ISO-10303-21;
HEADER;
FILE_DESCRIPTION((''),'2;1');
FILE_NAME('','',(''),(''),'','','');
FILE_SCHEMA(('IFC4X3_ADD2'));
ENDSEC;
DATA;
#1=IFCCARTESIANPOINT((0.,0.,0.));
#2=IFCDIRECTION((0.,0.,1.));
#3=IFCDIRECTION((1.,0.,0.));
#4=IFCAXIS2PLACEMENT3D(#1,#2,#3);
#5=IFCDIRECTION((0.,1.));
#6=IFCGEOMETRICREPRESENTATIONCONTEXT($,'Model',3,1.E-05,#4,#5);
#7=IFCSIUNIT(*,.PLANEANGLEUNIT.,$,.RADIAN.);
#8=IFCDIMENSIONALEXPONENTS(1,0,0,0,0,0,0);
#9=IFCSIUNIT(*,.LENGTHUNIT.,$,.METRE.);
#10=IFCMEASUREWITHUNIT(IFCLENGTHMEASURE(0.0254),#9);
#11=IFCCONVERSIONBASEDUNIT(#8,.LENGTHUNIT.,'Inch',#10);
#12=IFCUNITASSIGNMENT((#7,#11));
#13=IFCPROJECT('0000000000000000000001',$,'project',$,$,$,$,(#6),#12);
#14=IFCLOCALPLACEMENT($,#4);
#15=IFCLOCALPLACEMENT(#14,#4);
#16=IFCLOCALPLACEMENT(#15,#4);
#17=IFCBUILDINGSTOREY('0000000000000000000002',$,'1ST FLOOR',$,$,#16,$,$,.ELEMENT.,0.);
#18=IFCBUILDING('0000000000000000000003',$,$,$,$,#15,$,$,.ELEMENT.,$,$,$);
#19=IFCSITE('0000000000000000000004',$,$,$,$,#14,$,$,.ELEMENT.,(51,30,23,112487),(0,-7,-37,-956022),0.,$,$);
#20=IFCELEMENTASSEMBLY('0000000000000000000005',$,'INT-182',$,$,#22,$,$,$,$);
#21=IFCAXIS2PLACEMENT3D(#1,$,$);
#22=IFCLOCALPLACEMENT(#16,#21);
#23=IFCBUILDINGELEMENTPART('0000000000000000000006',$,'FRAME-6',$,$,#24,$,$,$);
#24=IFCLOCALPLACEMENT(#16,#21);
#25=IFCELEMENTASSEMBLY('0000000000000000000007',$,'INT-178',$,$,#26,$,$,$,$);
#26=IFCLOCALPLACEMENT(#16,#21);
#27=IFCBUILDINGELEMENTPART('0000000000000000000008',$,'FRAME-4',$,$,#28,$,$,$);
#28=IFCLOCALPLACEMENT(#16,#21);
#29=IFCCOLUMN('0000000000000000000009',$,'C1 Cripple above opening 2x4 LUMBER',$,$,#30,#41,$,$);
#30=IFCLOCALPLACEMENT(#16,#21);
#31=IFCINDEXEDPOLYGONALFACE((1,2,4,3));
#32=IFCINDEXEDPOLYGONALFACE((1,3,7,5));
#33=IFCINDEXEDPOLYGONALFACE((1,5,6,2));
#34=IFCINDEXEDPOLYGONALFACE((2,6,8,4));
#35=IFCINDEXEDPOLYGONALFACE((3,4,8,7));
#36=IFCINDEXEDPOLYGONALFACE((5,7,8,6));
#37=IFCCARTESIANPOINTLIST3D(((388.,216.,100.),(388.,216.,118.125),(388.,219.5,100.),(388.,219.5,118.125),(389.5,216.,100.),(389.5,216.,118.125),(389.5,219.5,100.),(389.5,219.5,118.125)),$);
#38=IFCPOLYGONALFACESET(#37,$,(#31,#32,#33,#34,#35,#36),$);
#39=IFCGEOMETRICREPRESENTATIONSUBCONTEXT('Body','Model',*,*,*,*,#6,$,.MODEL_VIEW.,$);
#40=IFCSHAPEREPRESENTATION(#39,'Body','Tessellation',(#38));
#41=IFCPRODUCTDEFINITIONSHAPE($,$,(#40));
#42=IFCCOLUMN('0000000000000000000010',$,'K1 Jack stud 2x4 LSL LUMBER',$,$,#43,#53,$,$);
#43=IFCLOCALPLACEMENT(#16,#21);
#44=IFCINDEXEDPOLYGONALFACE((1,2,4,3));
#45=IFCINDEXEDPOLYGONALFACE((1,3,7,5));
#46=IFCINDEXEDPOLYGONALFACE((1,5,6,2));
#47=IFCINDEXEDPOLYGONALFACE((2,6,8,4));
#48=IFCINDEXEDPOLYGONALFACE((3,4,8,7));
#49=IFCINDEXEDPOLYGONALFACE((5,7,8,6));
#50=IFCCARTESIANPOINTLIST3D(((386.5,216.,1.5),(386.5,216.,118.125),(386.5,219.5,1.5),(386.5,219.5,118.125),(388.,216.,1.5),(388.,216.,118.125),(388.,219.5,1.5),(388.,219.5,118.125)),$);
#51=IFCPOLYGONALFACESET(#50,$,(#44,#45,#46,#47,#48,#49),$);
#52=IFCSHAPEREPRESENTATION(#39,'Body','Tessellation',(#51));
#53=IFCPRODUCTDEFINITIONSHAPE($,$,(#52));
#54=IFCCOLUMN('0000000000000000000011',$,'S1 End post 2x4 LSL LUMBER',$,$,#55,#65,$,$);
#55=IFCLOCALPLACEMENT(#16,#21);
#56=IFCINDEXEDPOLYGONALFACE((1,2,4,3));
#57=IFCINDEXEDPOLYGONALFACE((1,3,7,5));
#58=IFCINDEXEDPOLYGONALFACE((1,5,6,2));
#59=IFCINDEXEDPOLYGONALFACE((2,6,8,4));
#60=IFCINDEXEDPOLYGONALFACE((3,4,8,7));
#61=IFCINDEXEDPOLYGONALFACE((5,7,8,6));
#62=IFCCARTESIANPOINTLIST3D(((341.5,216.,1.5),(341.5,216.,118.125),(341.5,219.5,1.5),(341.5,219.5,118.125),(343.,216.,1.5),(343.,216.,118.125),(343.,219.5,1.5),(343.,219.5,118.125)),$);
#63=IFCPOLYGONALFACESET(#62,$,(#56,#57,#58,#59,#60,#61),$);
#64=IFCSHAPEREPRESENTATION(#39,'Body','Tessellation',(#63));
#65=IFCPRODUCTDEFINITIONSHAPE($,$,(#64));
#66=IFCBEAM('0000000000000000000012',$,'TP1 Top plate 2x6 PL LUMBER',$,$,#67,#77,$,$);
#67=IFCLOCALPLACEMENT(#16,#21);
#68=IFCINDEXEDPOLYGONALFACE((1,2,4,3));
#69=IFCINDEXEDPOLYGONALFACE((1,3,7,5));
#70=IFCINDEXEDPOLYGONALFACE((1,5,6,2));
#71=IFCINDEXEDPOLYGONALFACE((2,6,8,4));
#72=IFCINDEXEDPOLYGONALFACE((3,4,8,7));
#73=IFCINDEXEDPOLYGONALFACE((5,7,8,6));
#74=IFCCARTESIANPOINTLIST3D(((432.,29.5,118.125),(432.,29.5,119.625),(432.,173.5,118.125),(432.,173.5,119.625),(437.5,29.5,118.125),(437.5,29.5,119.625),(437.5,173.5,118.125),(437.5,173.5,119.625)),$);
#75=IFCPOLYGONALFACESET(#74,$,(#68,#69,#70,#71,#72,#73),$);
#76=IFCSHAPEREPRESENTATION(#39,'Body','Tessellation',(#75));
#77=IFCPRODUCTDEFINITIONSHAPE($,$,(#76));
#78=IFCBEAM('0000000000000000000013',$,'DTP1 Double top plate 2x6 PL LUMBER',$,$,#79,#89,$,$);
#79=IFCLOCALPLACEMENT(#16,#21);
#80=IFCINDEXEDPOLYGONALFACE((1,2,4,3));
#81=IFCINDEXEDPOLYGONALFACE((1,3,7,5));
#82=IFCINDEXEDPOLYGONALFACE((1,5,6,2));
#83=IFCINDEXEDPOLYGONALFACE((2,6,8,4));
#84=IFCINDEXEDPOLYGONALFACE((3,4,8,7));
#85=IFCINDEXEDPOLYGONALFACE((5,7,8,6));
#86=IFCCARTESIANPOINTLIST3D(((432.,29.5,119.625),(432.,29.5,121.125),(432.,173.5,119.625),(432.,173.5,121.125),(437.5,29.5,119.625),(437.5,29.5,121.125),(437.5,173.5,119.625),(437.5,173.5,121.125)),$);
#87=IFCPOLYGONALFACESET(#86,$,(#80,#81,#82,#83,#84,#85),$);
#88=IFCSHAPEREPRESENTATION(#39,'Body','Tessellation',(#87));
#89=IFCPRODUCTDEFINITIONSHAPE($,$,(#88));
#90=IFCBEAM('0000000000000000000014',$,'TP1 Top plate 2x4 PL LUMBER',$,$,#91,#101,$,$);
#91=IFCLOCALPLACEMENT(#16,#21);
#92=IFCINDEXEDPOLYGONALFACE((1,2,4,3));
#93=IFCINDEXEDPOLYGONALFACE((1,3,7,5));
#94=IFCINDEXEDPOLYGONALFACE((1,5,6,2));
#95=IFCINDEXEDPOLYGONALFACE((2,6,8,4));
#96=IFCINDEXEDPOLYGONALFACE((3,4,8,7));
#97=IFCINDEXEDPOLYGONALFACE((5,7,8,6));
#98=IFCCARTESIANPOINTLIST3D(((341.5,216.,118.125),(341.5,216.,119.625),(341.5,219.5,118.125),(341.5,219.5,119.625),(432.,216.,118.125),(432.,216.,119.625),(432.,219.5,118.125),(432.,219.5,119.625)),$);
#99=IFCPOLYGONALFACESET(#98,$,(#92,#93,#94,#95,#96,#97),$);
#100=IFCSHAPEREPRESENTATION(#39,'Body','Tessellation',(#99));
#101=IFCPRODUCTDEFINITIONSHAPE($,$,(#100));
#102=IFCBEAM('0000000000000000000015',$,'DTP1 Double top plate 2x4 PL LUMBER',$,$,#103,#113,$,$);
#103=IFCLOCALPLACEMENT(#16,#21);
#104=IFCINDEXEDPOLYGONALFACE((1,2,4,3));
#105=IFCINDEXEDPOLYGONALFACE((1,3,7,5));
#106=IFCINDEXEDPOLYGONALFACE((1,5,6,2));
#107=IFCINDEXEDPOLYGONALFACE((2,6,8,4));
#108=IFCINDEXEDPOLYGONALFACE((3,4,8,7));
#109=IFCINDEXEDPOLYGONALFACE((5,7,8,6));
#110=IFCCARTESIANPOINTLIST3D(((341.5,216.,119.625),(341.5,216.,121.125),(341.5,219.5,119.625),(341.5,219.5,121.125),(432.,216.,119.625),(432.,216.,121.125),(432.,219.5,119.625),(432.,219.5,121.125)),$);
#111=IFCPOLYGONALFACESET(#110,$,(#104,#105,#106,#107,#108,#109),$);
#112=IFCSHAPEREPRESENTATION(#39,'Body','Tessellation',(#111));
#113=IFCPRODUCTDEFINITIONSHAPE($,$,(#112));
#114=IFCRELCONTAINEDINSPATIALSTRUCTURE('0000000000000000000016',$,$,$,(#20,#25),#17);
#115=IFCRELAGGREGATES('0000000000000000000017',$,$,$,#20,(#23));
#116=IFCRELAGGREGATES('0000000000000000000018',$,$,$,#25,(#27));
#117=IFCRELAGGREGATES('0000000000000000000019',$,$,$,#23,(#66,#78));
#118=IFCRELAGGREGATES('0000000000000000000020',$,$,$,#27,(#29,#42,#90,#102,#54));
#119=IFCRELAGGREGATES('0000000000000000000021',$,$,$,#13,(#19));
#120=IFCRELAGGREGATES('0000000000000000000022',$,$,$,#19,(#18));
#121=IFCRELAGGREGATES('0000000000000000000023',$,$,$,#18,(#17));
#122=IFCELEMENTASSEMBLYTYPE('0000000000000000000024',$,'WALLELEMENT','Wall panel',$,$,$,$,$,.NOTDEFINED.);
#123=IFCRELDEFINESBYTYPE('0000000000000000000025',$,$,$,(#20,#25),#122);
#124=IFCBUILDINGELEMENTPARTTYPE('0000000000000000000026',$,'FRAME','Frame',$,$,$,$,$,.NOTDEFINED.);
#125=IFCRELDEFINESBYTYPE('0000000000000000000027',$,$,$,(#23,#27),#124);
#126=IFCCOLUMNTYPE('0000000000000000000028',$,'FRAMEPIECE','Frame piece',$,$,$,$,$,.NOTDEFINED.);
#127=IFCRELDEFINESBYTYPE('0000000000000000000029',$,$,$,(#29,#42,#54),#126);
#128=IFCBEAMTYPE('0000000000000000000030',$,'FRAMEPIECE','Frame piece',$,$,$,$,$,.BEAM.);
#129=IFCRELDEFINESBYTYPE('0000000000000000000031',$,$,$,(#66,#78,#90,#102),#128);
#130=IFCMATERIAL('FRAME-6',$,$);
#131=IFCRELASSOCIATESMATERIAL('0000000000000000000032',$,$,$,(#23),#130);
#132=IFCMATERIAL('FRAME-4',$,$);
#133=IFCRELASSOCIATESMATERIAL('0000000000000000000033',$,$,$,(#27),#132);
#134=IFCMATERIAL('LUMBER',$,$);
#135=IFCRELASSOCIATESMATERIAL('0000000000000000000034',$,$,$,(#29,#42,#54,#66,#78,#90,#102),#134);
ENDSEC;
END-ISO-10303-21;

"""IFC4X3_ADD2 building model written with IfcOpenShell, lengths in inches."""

from ifc_helpers import new_model, entity, si_unit, converted_unit, direction, frame, origin_with_axes, origin_2d_with_axis, place, context, subcontext, project, spatial, rectangle, extrude, material, type_object, element, aggregate, save


model = new_model("IFC4X3_ADD2")

# Units and contexts
model_context = context("Model", 3, precision=1e-05, world=origin_with_axes(), true_north=direction((0.0, 1.0)))
body_context = subcontext(model_context, "Body", "Model", "MODEL_VIEW")
ifc_project = project(units=[si_unit("PLANEANGLEUNIT", "RADIAN"), converted_unit("LENGTHUNIT", "Inch", entity("IfcLengthMeasure", 0.0254), si_unit("LENGTHUNIT", "METRE"), dimensions=[1, 0, 0, 0, 0, 0, 0])], contexts=[model_context])

# Site, building, storey
site_placement = place(None, origin_with_axes())
site = spatial("IfcSite", under=ifc_project, at=site_placement, CompositionType="ELEMENT", RefLatitude=(51, 30, 23, 112487), RefLongitude=(0, -7, -37, -956022), RefElevation=0.0)
building_placement = place(site_placement, origin_with_axes())
building = spatial("IfcBuilding", under=site, at=building_placement, CompositionType="ELEMENT")
storey_placement = place(building_placement, origin_with_axes())
storey = spatial("IfcBuildingStorey", under=building, at=storey_placement, Name="1ST FLOOR", CompositionType="ELEMENT", Elevation=0.0)

# Element assemblies, building element parts, columns
element_assembly_type = type_object("IfcElementAssemblyType", Name="WALLELEMENT", Description="Wall panel", PredefinedType="NOTDEFINED")
ifc_material_1 = material(Name="FRAME-4")
building_element_part_type = type_object("IfcBuildingElementPartType", Name="FRAME", Description="Frame", PredefinedType="NOTDEFINED")
ifc_material_2 = material(Name="LUMBER")
column_type = type_object("IfcColumnType", Name="FRAMEPIECE", Description="Frame piece", PredefinedType="NOTDEFINED")
assembly_1_placement = place(storey_placement, origin_with_axes())
assembly_1 = element("IfcElementAssembly", 1, at=assembly_1_placement, inside=storey, type_object=element_assembly_type, Name="INT-182")
ifc_material_3 = material(Name="FRAME-6")
building_element_part_1_placement = place(storey_placement, origin_with_axes())
building_element_part_1 = element("IfcBuildingElementPart", 2, at=building_element_part_1_placement, type_object=building_element_part_type, material=ifc_material_3, Name="FRAME-6")
aggregate(assembly_1, [building_element_part_1])
assembly_2_placement = place(storey_placement, origin_with_axes())
assembly_2 = element("IfcElementAssembly", 3, at=assembly_2_placement, inside=storey, type_object=element_assembly_type, Name="INT-178")
building_element_part_2_placement = place(storey_placement, origin_with_axes())
building_element_part_2 = element("IfcBuildingElementPart", 4, at=building_element_part_2_placement, type_object=building_element_part_type, material=ifc_material_1, Name="FRAME-4")
aggregate(assembly_2, [building_element_part_2])
column_1_placement = place(storey_placement, frame((388.75, 217.75, 118.125), z_axis=(0.0, 0.0, -1.0), x_axis=(1.0, 0.0, 0.0)))
column_1 = element("IfcColumn", 5, at=column_1_placement, type_object=column_type, material=ifc_material_2, Name="C1 Cripple above opening 2x4 LUMBER", context=body_context, shape_type="SweptSolid", body=[
    extrude(rectangle(XDim=1.5, YDim=3.5, at=origin_2d_with_axis()), origin_with_axes(), (0.0, 0.0, 1.0), 18.125),
])
column_2_placement = place(storey_placement, frame((387.25, 217.75, 118.125), z_axis=(0.0, 0.0, -1.0), x_axis=(1.0, 0.0, 0.0)))
column_2 = element("IfcColumn", 6, at=column_2_placement, type_object=column_type, material=ifc_material_2, Name="K1 Jack stud 2x4 LSL LUMBER", context=body_context, shape_type="SweptSolid", body=[
    extrude(rectangle(XDim=1.5, YDim=3.5, at=origin_2d_with_axis()), origin_with_axes(), (0.0, 0.0, 1.0), 116.625),
])
column_3_placement = place(storey_placement, frame((342.25, 217.75, 118.125), z_axis=(0.0, 0.0, -1.0), x_axis=(1.0, 0.0, 0.0)))
column_3 = element("IfcColumn", 7, at=column_3_placement, type_object=column_type, material=ifc_material_2, Name="S1 End post 2x4 LSL LUMBER", context=body_context, shape_type="SweptSolid", body=[
    extrude(rectangle(XDim=1.5, YDim=3.5, at=origin_2d_with_axis()), origin_with_axes(), (0.0, 0.0, 1.0), 116.625),
])

# Beams
beam_type = type_object("IfcBeamType", Name="FRAMEPIECE", Description="Frame piece", PredefinedType="BEAM")
beam_1_placement = place(storey_placement, frame((434.75, 173.5, 118.875), z_axis=(0.0, -1.0, 0.0), x_axis=(0.0, 0.0, -1.0)))
beam_1 = element("IfcBeam", 8, at=beam_1_placement, type_object=beam_type, material=ifc_material_2, Name="TP1 Top plate 2x6 PL LUMBER", context=body_context, shape_type="SweptSolid", body=[
    extrude(rectangle(XDim=1.5, YDim=5.5, at=origin_2d_with_axis()), origin_with_axes(), (0.0, 0.0, 1.0), 144.0),
])
beam_2_placement = place(storey_placement, frame((434.75, 173.5, 120.375), z_axis=(0.0, -1.0, 0.0), x_axis=(0.0, 0.0, -1.0)))
beam_2 = element("IfcBeam", 9, at=beam_2_placement, type_object=beam_type, material=ifc_material_2, Name="DTP1 Double top plate 2x6 PL LUMBER", context=body_context, shape_type="SweptSolid", body=[
    extrude(rectangle(XDim=1.5, YDim=5.5, at=origin_2d_with_axis()), origin_with_axes(), (0.0, 0.0, 1.0), 144.0),
])
aggregate(building_element_part_1, [beam_1, beam_2])
beam_3_placement = place(storey_placement, frame((432.0, 217.75, 118.875), z_axis=(-1.0, 0.0, 0.0), x_axis=(0.0, 0.0, -1.0)))
beam_3 = element("IfcBeam", 10, at=beam_3_placement, type_object=beam_type, material=ifc_material_2, Name="TP1 Top plate 2x4 PL LUMBER", context=body_context, shape_type="SweptSolid", body=[
    extrude(rectangle(XDim=1.5, YDim=3.5, at=origin_2d_with_axis()), origin_with_axes(), (0.0, 0.0, 1.0), 90.5),
])
beam_4_placement = place(storey_placement, frame((432.0, 217.75, 120.375), z_axis=(-1.0, 0.0, 0.0), x_axis=(0.0, 0.0, -1.0)))
beam_4 = element("IfcBeam", 11, at=beam_4_placement, type_object=beam_type, material=ifc_material_2, Name="DTP1 Double top plate 2x4 PL LUMBER", context=body_context, shape_type="SweptSolid", body=[
    extrude(rectangle(XDim=1.5, YDim=3.5, at=origin_2d_with_axis()), origin_with_axes(), (0.0, 0.0, 1.0), 90.5),
])
aggregate(building_element_part_2, [column_1, column_2, beam_3, beam_4, column_3])

save(model, "model.ifc")
